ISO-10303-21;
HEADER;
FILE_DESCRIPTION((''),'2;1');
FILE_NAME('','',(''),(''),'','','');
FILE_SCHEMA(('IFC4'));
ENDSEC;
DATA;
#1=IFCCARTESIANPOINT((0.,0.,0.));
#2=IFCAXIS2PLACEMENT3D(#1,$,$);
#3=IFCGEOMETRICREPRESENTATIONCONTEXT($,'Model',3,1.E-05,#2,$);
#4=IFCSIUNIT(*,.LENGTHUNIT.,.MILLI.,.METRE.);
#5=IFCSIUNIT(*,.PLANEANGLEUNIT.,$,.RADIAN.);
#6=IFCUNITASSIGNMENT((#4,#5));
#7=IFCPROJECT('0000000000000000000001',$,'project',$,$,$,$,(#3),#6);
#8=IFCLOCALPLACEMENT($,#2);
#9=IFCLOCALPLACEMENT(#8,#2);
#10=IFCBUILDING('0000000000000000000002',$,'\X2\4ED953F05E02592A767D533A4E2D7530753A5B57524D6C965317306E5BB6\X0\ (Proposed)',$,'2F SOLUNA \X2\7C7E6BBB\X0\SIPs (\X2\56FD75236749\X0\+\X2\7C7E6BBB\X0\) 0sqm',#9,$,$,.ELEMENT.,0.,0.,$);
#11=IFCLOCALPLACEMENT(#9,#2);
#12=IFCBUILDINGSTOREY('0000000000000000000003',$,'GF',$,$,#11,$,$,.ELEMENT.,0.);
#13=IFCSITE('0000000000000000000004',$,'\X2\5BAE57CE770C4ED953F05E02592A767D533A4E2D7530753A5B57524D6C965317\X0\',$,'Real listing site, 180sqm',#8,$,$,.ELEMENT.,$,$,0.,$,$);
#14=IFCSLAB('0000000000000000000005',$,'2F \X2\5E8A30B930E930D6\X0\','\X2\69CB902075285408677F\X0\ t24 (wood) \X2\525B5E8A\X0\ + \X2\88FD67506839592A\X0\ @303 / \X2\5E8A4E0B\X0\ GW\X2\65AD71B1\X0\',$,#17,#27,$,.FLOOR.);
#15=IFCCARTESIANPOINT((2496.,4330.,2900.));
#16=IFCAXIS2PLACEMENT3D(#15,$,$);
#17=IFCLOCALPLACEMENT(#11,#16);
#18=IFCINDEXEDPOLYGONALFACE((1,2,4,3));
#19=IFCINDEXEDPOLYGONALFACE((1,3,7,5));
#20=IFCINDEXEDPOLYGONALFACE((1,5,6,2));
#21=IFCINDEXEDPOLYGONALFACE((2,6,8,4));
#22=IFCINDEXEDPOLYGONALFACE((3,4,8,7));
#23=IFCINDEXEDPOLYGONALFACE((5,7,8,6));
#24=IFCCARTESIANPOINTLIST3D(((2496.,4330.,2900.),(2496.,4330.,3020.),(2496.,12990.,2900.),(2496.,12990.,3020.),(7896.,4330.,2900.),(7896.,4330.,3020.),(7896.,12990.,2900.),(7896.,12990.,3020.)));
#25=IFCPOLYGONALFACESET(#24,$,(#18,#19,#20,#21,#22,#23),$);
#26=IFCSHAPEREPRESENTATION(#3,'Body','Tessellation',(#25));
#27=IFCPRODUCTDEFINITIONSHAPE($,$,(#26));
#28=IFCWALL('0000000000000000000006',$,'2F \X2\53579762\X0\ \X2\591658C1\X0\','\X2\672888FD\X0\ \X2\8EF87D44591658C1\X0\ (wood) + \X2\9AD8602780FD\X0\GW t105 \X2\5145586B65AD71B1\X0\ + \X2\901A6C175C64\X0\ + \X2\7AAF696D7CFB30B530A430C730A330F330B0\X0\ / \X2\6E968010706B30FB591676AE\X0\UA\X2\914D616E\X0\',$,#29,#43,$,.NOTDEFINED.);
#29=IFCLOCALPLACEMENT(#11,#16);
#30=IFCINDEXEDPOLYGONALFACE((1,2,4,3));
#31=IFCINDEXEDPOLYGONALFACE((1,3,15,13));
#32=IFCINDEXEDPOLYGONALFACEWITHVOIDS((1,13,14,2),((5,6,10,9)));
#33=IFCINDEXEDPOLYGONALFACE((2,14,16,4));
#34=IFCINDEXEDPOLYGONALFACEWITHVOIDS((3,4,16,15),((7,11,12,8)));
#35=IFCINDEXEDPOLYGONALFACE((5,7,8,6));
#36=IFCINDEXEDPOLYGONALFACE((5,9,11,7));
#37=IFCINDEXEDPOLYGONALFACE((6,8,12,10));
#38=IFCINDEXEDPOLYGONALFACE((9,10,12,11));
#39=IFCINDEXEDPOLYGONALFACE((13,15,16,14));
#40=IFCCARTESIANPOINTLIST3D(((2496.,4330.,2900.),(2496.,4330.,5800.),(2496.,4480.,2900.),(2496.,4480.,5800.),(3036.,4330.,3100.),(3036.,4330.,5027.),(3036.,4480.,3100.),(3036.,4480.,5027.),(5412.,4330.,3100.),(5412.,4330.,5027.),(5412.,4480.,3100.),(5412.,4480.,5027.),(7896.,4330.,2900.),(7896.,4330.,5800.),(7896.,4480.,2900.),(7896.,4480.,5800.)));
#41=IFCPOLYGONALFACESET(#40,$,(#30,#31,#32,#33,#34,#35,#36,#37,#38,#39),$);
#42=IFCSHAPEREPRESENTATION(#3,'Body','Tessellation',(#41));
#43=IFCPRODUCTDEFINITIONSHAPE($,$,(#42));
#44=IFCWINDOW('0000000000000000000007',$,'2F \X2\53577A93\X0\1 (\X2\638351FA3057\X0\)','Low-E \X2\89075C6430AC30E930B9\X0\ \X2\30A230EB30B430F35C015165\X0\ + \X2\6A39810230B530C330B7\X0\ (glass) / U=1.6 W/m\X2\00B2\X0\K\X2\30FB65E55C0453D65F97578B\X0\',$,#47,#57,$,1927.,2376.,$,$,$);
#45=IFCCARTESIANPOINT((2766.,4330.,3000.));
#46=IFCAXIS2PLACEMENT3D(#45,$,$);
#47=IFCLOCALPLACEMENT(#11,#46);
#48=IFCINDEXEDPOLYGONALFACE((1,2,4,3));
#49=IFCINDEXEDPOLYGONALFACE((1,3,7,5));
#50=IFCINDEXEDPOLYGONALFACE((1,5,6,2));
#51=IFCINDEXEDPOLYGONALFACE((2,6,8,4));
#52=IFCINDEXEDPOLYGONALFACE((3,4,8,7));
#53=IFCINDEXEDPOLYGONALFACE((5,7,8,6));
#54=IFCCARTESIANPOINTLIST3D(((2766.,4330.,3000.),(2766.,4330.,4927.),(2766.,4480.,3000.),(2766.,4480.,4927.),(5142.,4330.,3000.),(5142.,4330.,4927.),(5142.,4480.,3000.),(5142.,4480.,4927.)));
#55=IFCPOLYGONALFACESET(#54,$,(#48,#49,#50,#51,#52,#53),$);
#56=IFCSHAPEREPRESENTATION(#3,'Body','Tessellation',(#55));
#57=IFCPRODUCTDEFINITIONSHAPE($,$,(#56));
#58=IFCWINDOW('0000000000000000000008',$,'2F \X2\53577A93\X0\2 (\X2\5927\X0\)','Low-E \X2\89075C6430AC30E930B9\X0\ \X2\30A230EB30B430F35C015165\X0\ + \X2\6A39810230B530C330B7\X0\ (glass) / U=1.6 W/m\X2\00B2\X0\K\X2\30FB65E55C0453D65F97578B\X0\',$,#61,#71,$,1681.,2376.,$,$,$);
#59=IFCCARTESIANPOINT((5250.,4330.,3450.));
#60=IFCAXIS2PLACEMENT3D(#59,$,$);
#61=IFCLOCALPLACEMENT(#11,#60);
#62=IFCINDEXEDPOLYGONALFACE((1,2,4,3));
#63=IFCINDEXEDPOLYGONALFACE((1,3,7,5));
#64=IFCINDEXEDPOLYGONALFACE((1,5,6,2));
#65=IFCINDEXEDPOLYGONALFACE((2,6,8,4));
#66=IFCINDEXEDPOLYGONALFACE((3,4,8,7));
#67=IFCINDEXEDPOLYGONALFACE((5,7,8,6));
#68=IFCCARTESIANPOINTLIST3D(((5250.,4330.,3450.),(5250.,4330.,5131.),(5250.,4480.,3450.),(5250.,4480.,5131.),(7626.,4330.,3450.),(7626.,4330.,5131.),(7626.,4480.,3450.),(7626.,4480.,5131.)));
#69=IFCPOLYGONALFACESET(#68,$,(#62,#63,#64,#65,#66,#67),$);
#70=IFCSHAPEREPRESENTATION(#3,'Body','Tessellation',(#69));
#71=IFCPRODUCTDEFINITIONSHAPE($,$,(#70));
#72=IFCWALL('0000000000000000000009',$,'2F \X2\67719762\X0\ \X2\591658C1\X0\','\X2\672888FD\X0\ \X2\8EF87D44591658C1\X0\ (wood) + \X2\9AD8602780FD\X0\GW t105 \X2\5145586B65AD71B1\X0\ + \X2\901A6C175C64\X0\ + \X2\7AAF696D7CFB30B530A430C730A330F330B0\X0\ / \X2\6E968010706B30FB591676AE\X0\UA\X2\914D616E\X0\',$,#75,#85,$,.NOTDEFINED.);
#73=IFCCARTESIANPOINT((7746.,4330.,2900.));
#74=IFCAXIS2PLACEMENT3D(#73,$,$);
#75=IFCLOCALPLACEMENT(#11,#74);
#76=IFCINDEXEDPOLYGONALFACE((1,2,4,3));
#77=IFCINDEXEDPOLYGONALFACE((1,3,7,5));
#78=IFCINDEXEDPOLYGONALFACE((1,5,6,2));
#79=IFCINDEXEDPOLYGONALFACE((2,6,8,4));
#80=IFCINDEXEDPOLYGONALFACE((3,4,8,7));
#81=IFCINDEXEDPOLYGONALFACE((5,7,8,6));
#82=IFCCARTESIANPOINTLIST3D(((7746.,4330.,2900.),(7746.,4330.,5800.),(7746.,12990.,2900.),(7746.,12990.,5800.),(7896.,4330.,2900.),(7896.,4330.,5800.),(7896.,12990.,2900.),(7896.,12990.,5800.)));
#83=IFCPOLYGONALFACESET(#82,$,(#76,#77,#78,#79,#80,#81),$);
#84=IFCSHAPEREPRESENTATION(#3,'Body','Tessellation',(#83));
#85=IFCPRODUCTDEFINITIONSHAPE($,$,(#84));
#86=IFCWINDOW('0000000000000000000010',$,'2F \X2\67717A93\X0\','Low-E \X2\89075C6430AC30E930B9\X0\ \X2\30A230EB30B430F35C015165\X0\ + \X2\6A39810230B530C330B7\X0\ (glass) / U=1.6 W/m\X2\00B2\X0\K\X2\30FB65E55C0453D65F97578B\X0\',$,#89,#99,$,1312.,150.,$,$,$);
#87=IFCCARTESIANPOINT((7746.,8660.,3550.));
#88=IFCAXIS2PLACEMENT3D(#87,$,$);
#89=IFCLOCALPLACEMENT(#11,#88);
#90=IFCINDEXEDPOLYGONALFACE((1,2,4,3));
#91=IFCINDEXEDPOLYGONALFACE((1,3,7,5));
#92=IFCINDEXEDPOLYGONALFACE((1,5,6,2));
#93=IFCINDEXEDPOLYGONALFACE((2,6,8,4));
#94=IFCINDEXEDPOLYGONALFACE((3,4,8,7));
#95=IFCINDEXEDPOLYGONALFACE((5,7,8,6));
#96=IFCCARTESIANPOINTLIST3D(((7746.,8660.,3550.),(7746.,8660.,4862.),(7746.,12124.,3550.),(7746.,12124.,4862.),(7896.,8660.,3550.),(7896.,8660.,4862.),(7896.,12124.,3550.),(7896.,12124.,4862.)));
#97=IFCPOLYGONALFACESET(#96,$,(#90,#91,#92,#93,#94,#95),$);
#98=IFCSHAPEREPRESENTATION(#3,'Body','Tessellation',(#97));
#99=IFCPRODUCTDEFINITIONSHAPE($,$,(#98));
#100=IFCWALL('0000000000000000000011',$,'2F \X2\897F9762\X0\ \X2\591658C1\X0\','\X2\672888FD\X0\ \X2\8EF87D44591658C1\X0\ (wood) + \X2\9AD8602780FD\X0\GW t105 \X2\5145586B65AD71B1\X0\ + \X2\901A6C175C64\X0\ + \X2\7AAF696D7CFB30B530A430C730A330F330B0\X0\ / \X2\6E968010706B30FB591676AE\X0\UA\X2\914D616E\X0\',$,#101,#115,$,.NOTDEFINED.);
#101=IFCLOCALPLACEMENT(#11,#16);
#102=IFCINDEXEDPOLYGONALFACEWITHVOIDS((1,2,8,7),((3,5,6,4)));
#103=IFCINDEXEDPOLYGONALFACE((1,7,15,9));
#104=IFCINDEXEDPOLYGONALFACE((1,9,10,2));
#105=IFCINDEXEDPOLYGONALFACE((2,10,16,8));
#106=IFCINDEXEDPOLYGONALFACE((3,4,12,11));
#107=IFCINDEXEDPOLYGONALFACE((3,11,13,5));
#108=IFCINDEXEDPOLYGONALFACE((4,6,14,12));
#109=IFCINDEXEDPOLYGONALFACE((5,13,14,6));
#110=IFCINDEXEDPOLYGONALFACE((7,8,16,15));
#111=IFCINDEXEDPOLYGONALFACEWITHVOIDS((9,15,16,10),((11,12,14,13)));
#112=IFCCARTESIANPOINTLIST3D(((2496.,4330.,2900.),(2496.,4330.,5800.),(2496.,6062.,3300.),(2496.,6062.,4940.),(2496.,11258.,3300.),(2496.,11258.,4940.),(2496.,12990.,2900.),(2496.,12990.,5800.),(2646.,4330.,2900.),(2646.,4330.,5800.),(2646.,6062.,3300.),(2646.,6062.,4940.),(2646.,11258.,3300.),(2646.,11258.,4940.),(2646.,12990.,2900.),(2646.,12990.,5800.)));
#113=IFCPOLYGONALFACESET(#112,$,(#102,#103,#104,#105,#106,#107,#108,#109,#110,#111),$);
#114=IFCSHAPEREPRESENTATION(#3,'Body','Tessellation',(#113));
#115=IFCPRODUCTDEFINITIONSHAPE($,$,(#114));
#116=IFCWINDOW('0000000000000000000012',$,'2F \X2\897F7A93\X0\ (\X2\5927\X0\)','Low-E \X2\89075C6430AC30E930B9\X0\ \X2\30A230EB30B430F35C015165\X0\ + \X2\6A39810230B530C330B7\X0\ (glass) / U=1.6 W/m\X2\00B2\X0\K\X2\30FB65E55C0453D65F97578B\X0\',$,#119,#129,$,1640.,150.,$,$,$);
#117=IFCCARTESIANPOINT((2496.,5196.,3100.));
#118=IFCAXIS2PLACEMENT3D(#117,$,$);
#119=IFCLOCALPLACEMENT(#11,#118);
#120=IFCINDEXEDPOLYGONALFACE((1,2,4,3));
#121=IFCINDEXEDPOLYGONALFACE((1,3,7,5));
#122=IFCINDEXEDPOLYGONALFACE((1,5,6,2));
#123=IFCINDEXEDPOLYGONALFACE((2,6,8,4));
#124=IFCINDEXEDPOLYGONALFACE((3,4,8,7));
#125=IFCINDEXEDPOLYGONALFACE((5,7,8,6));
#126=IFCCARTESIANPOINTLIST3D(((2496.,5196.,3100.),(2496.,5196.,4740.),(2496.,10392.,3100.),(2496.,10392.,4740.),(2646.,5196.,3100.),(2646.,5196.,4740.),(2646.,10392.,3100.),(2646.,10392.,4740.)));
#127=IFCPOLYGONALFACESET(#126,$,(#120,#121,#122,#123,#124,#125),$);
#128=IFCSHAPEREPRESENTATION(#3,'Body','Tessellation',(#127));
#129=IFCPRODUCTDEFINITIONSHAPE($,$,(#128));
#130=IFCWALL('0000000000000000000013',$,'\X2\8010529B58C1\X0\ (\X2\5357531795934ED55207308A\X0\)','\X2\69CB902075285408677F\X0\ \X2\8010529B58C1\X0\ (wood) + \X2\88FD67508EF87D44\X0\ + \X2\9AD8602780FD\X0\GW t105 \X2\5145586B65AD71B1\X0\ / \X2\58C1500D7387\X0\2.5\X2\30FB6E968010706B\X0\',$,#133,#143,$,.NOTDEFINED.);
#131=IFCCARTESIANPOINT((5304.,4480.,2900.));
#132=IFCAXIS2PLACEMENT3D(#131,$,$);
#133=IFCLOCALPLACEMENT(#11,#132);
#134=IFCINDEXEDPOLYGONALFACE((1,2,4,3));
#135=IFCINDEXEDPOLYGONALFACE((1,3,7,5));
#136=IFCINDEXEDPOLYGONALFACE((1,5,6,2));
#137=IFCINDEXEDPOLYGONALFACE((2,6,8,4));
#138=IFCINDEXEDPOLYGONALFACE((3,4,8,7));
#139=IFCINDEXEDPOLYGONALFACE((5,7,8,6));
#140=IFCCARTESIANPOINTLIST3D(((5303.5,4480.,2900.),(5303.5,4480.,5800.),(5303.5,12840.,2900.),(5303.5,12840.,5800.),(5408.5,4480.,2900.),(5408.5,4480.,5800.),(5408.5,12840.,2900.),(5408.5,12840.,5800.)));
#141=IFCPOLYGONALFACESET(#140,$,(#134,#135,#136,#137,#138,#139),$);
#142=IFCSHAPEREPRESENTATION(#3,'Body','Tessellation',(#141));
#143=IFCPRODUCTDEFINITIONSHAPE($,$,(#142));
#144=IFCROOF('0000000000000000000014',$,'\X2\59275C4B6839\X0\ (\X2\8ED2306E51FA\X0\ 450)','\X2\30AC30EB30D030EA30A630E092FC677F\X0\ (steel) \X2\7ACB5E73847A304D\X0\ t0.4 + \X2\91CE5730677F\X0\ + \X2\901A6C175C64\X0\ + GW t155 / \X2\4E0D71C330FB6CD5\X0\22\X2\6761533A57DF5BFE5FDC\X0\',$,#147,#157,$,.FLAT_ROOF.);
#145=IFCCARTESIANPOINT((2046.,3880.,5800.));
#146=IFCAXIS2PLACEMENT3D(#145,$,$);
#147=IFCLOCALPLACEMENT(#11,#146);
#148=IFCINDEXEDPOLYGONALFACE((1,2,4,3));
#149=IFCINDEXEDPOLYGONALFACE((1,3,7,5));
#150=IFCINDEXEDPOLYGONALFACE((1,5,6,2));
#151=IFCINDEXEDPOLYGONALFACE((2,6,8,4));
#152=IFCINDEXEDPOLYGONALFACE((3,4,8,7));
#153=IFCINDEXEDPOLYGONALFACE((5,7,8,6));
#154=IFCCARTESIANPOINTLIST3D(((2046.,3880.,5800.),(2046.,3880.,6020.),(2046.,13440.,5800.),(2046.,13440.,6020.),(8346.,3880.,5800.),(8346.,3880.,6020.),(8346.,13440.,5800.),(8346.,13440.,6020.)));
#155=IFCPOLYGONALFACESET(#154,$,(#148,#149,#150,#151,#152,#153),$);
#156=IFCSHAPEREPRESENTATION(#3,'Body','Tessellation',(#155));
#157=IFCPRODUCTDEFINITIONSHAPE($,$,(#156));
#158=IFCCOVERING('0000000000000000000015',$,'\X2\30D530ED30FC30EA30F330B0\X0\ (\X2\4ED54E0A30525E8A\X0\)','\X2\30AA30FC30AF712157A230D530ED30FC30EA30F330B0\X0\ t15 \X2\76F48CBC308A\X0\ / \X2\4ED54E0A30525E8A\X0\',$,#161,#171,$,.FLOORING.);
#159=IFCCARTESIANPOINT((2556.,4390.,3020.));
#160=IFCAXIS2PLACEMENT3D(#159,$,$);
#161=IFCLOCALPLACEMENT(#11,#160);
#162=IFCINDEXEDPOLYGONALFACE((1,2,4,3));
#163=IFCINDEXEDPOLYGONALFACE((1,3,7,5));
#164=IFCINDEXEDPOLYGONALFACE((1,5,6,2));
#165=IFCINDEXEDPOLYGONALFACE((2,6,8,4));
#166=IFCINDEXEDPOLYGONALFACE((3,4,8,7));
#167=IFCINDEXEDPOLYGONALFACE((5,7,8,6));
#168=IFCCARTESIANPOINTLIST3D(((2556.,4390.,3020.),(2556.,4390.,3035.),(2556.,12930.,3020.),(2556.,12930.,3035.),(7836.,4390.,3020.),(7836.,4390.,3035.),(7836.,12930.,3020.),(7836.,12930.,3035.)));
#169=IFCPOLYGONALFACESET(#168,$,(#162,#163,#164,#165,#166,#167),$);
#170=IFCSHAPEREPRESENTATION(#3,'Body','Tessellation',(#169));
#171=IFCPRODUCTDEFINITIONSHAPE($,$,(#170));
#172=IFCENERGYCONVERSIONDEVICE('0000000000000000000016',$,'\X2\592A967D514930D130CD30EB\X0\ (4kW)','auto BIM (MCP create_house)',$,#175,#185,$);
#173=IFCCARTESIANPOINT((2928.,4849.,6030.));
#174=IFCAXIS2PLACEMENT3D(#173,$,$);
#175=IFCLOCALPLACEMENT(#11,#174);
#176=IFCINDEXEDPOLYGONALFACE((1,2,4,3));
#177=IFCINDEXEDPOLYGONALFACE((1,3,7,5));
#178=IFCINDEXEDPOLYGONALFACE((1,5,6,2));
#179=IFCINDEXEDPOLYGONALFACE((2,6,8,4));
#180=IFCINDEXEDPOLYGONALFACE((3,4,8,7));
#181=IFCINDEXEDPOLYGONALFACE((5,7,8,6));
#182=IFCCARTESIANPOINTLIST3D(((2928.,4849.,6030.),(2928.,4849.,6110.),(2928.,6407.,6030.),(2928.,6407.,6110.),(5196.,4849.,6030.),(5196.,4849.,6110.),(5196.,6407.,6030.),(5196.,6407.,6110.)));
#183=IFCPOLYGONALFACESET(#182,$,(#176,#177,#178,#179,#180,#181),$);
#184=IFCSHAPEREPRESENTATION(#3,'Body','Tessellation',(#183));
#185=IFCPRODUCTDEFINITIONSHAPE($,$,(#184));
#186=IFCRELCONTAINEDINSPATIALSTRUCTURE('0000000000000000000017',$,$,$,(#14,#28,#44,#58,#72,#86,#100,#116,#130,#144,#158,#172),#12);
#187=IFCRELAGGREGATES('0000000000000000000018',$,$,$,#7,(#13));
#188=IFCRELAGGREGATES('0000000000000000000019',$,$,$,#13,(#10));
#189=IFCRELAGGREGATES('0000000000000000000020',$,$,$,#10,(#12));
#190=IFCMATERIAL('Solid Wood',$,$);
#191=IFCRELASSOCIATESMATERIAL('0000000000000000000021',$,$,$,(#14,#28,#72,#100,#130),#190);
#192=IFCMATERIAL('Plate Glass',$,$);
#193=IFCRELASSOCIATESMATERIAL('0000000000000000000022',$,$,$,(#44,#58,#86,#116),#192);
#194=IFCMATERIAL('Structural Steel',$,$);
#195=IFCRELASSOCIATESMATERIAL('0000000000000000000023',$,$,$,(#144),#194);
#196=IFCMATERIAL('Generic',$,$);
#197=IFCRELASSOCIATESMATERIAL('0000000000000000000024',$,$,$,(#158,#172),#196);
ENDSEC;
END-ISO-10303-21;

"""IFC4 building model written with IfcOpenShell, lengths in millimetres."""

from ifc_helpers import new_model, si_unit, frame, frame_2d, origin, place, context, project, spatial, rectangle, extrude, material, element, fill, save


model = new_model("IFC4")

# Units and contexts
model_context = context("Model", 3, precision=1e-05, world=origin())
ifc_project = project(units=[si_unit("LENGTHUNIT", "METRE", prefix="MILLI"), si_unit("PLANEANGLEUNIT", "RADIAN")], contexts=[model_context])

# Site, building, storey
site_placement = place(None, origin())
site = spatial("IfcSite", under=ifc_project, at=site_placement, Name="宮城県仙台市太白区中田町字前沖北", ObjectType="Real listing site, 180sqm", CompositionType="ELEMENT", RefElevation=0.0)
building_placement = place(site_placement, origin())
building = spatial("IfcBuilding", under=site, at=building_placement, Name="仙台市太白区中田町字前沖北の家 (Proposed)", ObjectType="2F SOLUNA 籾殻SIPs (国産杉+籾殻) 0sqm", CompositionType="ELEMENT", ElevationOfRefHeight=0.0, ElevationOfTerrain=0.0)
storey_placement = place(building_placement, origin())
storey = spatial("IfcBuildingStorey", under=building, at=storey_placement, Name="GF", CompositionType="ELEMENT", Elevation=0.0)

# Slab
ifc_material_1 = material(Name="Solid Wood")
slab_placement = place(storey_placement, frame((2496.0, 4330.0, 2900.0)))
element("IfcSlab", 1, at=slab_placement, inside=storey, material=ifc_material_1, Name="2F 床スラブ", Description="構造用合板 t24 (wood) 剛床 + 製材根太 @303 / 床下 GW断熱", PredefinedType="FLOOR", context=model_context, shape_type="SweptSolid", body=[
    extrude(rectangle(XDim=5400.0, YDim=8660.0, at=frame_2d((2700.0, 4330.0))), frame((2496.0, 4330.0, 2900.0)), (0.0, 0.0, 1.0), 120.0),
])

# Wall, openings, windows
wall_1_placement = place(storey_placement, frame((2496.0, 4330.0, 2900.0)))
wall_1 = element("IfcWall", 2, at=wall_1_placement, inside=storey, material=ifc_material_1, Name="2F 南面 外壁", Description="木製 軸組外壁 (wood) + 高性能GW t105 充填断熱 + 通気層 + 窯業系サイディング / 準耐火・外皮UA配慮", PredefinedType="NOTDEFINED", context=model_context, shape_type="SweptSolid", body=[
    extrude(rectangle(XDim=5400.0, YDim=150.0, at=frame_2d((2700.0, 75.0))), frame((2496.0, 4330.0, 2900.0)), (0.0, 0.0, 1.0), 2900.0),
])
opening_1_placement = place(storey_placement, frame((2766.0, 4330.0, 3000.0)))
opening_1 = element("IfcOpeningElement", 3, at=opening_1_placement, cuts=wall_1, PredefinedType="NOTDEFINED", context=model_context, shape_type="SweptSolid", body=[
    extrude(rectangle(XDim=2376.0, YDim=150.0, at=frame_2d((1188.0, 75.0))), frame((2766.0, 4330.0, 3000.0)), (0.0, 0.0, 1.0), 1927.0),
])
opening_2_placement = place(storey_placement, frame((5250.0, 4330.0, 3450.0)))
opening_2 = element("IfcOpeningElement", 4, at=opening_2_placement, cuts=wall_1, PredefinedType="NOTDEFINED", context=model_context, shape_type="SweptSolid", body=[
    extrude(rectangle(XDim=2376.0, YDim=150.0, at=frame_2d((1188.0, 75.0))), frame((5250.0, 4330.0, 3450.0)), (0.0, 0.0, 1.0), 1681.0),
])
ifc_material_2 = material(Name="Plate Glass")
window_1_placement = place(storey_placement, frame((2766.0, 4330.0, 3000.0)))
window_1 = element("IfcWindow", 5, at=window_1_placement, inside=storey, material=ifc_material_2, Name="2F 南窓1 (掃出し)", Description="Low-E 複層ガラス アルゴン封入 + 樹脂サッシ (glass) / U=1.6 W/m²K・日射取得型", OverallHeight=1927.0, OverallWidth=2376.0, context=model_context, shape_type="SweptSolid", body=[
    extrude(rectangle(XDim=2376.0, YDim=150.0, at=frame_2d((1188.0, 75.0))), frame((2766.0, 4330.0, 3000.0)), (0.0, 0.0, 1.0), 1927.0),
])
fill(opening_1, window_1)
window_2_placement = place(storey_placement, frame((5250.0, 4330.0, 3450.0)))
window_2 = element("IfcWindow", 6, at=window_2_placement, inside=storey, material=ifc_material_2, Name="2F 南窓2 (大)", Description="Low-E 複層ガラス アルゴン封入 + 樹脂サッシ (glass) / U=1.6 W/m²K・日射取得型", OverallHeight=1681.0, OverallWidth=2376.0, context=model_context, shape_type="SweptSolid", body=[
    extrude(rectangle(XDim=2376.0, YDim=150.0, at=frame_2d((1188.0, 75.0))), frame((5250.0, 4330.0, 3450.0)), (0.0, 0.0, 1.0), 1681.0),
])
fill(opening_2, window_2)

# Walls, openings, windows
wall_2_placement = place(storey_placement, frame((7746.0, 4330.0, 2900.0)))
wall_2 = element("IfcWall", 7, at=wall_2_placement, inside=storey, material=ifc_material_1, Name="2F 東面 外壁", Description="木製 軸組外壁 (wood) + 高性能GW t105 充填断熱 + 通気層 + 窯業系サイディング / 準耐火・外皮UA配慮", PredefinedType="NOTDEFINED", context=model_context, shape_type="SweptSolid", body=[
    extrude(rectangle(XDim=150.0, YDim=8660.0, at=frame_2d((75.0, 4330.0))), frame((7746.0, 4330.0, 2900.0)), (0.0, 0.0, 1.0), 2900.0),
])
opening_3_placement = place(storey_placement, frame((7746.0, 8660.0, 3550.0)))
opening_3 = element("IfcOpeningElement", 8, at=opening_3_placement, cuts=wall_2, PredefinedType="NOTDEFINED", context=model_context, shape_type="SweptSolid", body=[
    extrude(rectangle(XDim=150.0, YDim=3464.0, at=frame_2d((75.0, 1732.0))), frame((7746.0, 8660.0, 3550.0)), (0.0, 0.0, 1.0), 1312.0),
])
window_3_placement = place(storey_placement, frame((7746.0, 8660.0, 3550.0)))
window_3 = element("IfcWindow", 9, at=window_3_placement, inside=storey, material=ifc_material_2, Name="2F 東窓", Description="Low-E 複層ガラス アルゴン封入 + 樹脂サッシ (glass) / U=1.6 W/m²K・日射取得型", OverallHeight=1312.0, OverallWidth=150.0, context=model_context, shape_type="SweptSolid", body=[
    extrude(rectangle(XDim=150.0, YDim=3464.0, at=frame_2d((75.0, 1732.0))), frame((7746.0, 8660.0, 3550.0)), (0.0, 0.0, 1.0), 1312.0),
])
fill(opening_3, window_3)
wall_3_placement = place(storey_placement, frame((2496.0, 4330.0, 2900.0)))
wall_3 = element("IfcWall", 10, at=wall_3_placement, inside=storey, material=ifc_material_1, Name="2F 西面 外壁", Description="木製 軸組外壁 (wood) + 高性能GW t105 充填断熱 + 通気層 + 窯業系サイディング / 準耐火・外皮UA配慮", PredefinedType="NOTDEFINED", context=model_context, shape_type="SweptSolid", body=[
    extrude(rectangle(XDim=150.0, YDim=8660.0, at=frame_2d((75.0, 4330.0))), frame((2496.0, 4330.0, 2900.0)), (0.0, 0.0, 1.0), 2900.0),
])
opening_4_placement = place(storey_placement, frame((2496.0, 5196.0, 3100.0)))
opening_4 = element("IfcOpeningElement", 11, at=opening_4_placement, cuts=wall_3, PredefinedType="NOTDEFINED", context=model_context, shape_type="SweptSolid", body=[
    extrude(rectangle(XDim=150.0, YDim=5196.0, at=frame_2d((75.0, 2598.0))), frame((2496.0, 5196.0, 3100.0)), (0.0, 0.0, 1.0), 1640.0),
])
window_4_placement = place(storey_placement, frame((2496.0, 5196.0, 3100.0)))
window_4 = element("IfcWindow", 12, at=window_4_placement, inside=storey, material=ifc_material_2, Name="2F 西窓 (大)", Description="Low-E 複層ガラス アルゴン封入 + 樹脂サッシ (glass) / U=1.6 W/m²K・日射取得型", OverallHeight=1640.0, OverallWidth=150.0, context=model_context, shape_type="SweptSolid", body=[
    extrude(rectangle(XDim=150.0, YDim=5196.0, at=frame_2d((75.0, 2598.0))), frame((2496.0, 5196.0, 3100.0)), (0.0, 0.0, 1.0), 1640.0),
])
fill(opening_4, window_4)

# Wall
wall_4_placement = place(storey_placement, frame((5304.0, 4480.0, 2900.0)))
element("IfcWall", 13, at=wall_4_placement, inside=storey, material=ifc_material_1, Name="耐力壁 (南北間仕切り)", Description="構造用合板 耐力壁 (wood) + 製材軸組 + 高性能GW t105 充填断熱 / 壁倍率2.5・準耐火", PredefinedType="NOTDEFINED", context=model_context, shape_type="SweptSolid", body=[
    extrude(rectangle(XDim=105.0, YDim=8360.0, at=frame_2d((52.0, 4180.0))), frame((5304.0, 4480.0, 2900.0)), (0.0, 0.0, 1.0), 2900.0),
])

# Roof
ifc_material_3 = material(Name="Structural Steel")
roof_placement = place(storey_placement, frame((2046.0, 3880.0, 5800.0)))
element("IfcRoof", 14, at=roof_placement, inside=storey, material=ifc_material_3, Name="大屋根 (軒の出 450)", Description="ガルバリウム鋼板 (steel) 立平葺き t0.4 + 野地板 + 通気層 + GW t155 / 不燃・法22条区域対応", PredefinedType="FLAT_ROOF", context=model_context, shape_type="SweptSolid", body=[
    extrude(rectangle(XDim=6300.0, YDim=9560.0, at=frame_2d((3150.0, 4780.0))), frame((2046.0, 3880.0, 5800.0)), (0.0, 0.0, 1.0), 220.0),
])

# Covering
ifc_material_4 = material(Name="Generic")
covering_placement = place(storey_placement, frame((2556.0, 4390.0, 3020.0)))
element("IfcCovering", 15, at=covering_placement, inside=storey, material=ifc_material_4, Name="フローリング (仕上げ床)", Description="オーク無垢フローリング t15 直貼り / 仕上げ床", PredefinedType="FLOORING", context=model_context, shape_type="SweptSolid", body=[
    extrude(rectangle(XDim=5280.0, YDim=8540.0, at=frame_2d((2640.0, 4270.0))), frame((2556.0, 4390.0, 3020.0)), (0.0, 0.0, 1.0), 15.0),
])

# Energy conversion device
energy_conversion_device_placement = place(storey_placement, frame((2928.0, 4849.0, 6030.0)))
element("IfcEnergyConversionDevice", 16, at=energy_conversion_device_placement, inside=storey, material=ifc_material_4, Name="太陽光パネル (4kW)", Description="auto BIM (MCP create_house)", context=model_context, shape_type="SweptSolid", body=[
    extrude(rectangle(XDim=2268.0, YDim=1558.0, at=frame_2d((1134.0, 779.0))), frame((2928.0, 4849.0, 6030.0)), (0.0, 0.0, 1.0), 80.0),
])

save(model, "model.ifc")
